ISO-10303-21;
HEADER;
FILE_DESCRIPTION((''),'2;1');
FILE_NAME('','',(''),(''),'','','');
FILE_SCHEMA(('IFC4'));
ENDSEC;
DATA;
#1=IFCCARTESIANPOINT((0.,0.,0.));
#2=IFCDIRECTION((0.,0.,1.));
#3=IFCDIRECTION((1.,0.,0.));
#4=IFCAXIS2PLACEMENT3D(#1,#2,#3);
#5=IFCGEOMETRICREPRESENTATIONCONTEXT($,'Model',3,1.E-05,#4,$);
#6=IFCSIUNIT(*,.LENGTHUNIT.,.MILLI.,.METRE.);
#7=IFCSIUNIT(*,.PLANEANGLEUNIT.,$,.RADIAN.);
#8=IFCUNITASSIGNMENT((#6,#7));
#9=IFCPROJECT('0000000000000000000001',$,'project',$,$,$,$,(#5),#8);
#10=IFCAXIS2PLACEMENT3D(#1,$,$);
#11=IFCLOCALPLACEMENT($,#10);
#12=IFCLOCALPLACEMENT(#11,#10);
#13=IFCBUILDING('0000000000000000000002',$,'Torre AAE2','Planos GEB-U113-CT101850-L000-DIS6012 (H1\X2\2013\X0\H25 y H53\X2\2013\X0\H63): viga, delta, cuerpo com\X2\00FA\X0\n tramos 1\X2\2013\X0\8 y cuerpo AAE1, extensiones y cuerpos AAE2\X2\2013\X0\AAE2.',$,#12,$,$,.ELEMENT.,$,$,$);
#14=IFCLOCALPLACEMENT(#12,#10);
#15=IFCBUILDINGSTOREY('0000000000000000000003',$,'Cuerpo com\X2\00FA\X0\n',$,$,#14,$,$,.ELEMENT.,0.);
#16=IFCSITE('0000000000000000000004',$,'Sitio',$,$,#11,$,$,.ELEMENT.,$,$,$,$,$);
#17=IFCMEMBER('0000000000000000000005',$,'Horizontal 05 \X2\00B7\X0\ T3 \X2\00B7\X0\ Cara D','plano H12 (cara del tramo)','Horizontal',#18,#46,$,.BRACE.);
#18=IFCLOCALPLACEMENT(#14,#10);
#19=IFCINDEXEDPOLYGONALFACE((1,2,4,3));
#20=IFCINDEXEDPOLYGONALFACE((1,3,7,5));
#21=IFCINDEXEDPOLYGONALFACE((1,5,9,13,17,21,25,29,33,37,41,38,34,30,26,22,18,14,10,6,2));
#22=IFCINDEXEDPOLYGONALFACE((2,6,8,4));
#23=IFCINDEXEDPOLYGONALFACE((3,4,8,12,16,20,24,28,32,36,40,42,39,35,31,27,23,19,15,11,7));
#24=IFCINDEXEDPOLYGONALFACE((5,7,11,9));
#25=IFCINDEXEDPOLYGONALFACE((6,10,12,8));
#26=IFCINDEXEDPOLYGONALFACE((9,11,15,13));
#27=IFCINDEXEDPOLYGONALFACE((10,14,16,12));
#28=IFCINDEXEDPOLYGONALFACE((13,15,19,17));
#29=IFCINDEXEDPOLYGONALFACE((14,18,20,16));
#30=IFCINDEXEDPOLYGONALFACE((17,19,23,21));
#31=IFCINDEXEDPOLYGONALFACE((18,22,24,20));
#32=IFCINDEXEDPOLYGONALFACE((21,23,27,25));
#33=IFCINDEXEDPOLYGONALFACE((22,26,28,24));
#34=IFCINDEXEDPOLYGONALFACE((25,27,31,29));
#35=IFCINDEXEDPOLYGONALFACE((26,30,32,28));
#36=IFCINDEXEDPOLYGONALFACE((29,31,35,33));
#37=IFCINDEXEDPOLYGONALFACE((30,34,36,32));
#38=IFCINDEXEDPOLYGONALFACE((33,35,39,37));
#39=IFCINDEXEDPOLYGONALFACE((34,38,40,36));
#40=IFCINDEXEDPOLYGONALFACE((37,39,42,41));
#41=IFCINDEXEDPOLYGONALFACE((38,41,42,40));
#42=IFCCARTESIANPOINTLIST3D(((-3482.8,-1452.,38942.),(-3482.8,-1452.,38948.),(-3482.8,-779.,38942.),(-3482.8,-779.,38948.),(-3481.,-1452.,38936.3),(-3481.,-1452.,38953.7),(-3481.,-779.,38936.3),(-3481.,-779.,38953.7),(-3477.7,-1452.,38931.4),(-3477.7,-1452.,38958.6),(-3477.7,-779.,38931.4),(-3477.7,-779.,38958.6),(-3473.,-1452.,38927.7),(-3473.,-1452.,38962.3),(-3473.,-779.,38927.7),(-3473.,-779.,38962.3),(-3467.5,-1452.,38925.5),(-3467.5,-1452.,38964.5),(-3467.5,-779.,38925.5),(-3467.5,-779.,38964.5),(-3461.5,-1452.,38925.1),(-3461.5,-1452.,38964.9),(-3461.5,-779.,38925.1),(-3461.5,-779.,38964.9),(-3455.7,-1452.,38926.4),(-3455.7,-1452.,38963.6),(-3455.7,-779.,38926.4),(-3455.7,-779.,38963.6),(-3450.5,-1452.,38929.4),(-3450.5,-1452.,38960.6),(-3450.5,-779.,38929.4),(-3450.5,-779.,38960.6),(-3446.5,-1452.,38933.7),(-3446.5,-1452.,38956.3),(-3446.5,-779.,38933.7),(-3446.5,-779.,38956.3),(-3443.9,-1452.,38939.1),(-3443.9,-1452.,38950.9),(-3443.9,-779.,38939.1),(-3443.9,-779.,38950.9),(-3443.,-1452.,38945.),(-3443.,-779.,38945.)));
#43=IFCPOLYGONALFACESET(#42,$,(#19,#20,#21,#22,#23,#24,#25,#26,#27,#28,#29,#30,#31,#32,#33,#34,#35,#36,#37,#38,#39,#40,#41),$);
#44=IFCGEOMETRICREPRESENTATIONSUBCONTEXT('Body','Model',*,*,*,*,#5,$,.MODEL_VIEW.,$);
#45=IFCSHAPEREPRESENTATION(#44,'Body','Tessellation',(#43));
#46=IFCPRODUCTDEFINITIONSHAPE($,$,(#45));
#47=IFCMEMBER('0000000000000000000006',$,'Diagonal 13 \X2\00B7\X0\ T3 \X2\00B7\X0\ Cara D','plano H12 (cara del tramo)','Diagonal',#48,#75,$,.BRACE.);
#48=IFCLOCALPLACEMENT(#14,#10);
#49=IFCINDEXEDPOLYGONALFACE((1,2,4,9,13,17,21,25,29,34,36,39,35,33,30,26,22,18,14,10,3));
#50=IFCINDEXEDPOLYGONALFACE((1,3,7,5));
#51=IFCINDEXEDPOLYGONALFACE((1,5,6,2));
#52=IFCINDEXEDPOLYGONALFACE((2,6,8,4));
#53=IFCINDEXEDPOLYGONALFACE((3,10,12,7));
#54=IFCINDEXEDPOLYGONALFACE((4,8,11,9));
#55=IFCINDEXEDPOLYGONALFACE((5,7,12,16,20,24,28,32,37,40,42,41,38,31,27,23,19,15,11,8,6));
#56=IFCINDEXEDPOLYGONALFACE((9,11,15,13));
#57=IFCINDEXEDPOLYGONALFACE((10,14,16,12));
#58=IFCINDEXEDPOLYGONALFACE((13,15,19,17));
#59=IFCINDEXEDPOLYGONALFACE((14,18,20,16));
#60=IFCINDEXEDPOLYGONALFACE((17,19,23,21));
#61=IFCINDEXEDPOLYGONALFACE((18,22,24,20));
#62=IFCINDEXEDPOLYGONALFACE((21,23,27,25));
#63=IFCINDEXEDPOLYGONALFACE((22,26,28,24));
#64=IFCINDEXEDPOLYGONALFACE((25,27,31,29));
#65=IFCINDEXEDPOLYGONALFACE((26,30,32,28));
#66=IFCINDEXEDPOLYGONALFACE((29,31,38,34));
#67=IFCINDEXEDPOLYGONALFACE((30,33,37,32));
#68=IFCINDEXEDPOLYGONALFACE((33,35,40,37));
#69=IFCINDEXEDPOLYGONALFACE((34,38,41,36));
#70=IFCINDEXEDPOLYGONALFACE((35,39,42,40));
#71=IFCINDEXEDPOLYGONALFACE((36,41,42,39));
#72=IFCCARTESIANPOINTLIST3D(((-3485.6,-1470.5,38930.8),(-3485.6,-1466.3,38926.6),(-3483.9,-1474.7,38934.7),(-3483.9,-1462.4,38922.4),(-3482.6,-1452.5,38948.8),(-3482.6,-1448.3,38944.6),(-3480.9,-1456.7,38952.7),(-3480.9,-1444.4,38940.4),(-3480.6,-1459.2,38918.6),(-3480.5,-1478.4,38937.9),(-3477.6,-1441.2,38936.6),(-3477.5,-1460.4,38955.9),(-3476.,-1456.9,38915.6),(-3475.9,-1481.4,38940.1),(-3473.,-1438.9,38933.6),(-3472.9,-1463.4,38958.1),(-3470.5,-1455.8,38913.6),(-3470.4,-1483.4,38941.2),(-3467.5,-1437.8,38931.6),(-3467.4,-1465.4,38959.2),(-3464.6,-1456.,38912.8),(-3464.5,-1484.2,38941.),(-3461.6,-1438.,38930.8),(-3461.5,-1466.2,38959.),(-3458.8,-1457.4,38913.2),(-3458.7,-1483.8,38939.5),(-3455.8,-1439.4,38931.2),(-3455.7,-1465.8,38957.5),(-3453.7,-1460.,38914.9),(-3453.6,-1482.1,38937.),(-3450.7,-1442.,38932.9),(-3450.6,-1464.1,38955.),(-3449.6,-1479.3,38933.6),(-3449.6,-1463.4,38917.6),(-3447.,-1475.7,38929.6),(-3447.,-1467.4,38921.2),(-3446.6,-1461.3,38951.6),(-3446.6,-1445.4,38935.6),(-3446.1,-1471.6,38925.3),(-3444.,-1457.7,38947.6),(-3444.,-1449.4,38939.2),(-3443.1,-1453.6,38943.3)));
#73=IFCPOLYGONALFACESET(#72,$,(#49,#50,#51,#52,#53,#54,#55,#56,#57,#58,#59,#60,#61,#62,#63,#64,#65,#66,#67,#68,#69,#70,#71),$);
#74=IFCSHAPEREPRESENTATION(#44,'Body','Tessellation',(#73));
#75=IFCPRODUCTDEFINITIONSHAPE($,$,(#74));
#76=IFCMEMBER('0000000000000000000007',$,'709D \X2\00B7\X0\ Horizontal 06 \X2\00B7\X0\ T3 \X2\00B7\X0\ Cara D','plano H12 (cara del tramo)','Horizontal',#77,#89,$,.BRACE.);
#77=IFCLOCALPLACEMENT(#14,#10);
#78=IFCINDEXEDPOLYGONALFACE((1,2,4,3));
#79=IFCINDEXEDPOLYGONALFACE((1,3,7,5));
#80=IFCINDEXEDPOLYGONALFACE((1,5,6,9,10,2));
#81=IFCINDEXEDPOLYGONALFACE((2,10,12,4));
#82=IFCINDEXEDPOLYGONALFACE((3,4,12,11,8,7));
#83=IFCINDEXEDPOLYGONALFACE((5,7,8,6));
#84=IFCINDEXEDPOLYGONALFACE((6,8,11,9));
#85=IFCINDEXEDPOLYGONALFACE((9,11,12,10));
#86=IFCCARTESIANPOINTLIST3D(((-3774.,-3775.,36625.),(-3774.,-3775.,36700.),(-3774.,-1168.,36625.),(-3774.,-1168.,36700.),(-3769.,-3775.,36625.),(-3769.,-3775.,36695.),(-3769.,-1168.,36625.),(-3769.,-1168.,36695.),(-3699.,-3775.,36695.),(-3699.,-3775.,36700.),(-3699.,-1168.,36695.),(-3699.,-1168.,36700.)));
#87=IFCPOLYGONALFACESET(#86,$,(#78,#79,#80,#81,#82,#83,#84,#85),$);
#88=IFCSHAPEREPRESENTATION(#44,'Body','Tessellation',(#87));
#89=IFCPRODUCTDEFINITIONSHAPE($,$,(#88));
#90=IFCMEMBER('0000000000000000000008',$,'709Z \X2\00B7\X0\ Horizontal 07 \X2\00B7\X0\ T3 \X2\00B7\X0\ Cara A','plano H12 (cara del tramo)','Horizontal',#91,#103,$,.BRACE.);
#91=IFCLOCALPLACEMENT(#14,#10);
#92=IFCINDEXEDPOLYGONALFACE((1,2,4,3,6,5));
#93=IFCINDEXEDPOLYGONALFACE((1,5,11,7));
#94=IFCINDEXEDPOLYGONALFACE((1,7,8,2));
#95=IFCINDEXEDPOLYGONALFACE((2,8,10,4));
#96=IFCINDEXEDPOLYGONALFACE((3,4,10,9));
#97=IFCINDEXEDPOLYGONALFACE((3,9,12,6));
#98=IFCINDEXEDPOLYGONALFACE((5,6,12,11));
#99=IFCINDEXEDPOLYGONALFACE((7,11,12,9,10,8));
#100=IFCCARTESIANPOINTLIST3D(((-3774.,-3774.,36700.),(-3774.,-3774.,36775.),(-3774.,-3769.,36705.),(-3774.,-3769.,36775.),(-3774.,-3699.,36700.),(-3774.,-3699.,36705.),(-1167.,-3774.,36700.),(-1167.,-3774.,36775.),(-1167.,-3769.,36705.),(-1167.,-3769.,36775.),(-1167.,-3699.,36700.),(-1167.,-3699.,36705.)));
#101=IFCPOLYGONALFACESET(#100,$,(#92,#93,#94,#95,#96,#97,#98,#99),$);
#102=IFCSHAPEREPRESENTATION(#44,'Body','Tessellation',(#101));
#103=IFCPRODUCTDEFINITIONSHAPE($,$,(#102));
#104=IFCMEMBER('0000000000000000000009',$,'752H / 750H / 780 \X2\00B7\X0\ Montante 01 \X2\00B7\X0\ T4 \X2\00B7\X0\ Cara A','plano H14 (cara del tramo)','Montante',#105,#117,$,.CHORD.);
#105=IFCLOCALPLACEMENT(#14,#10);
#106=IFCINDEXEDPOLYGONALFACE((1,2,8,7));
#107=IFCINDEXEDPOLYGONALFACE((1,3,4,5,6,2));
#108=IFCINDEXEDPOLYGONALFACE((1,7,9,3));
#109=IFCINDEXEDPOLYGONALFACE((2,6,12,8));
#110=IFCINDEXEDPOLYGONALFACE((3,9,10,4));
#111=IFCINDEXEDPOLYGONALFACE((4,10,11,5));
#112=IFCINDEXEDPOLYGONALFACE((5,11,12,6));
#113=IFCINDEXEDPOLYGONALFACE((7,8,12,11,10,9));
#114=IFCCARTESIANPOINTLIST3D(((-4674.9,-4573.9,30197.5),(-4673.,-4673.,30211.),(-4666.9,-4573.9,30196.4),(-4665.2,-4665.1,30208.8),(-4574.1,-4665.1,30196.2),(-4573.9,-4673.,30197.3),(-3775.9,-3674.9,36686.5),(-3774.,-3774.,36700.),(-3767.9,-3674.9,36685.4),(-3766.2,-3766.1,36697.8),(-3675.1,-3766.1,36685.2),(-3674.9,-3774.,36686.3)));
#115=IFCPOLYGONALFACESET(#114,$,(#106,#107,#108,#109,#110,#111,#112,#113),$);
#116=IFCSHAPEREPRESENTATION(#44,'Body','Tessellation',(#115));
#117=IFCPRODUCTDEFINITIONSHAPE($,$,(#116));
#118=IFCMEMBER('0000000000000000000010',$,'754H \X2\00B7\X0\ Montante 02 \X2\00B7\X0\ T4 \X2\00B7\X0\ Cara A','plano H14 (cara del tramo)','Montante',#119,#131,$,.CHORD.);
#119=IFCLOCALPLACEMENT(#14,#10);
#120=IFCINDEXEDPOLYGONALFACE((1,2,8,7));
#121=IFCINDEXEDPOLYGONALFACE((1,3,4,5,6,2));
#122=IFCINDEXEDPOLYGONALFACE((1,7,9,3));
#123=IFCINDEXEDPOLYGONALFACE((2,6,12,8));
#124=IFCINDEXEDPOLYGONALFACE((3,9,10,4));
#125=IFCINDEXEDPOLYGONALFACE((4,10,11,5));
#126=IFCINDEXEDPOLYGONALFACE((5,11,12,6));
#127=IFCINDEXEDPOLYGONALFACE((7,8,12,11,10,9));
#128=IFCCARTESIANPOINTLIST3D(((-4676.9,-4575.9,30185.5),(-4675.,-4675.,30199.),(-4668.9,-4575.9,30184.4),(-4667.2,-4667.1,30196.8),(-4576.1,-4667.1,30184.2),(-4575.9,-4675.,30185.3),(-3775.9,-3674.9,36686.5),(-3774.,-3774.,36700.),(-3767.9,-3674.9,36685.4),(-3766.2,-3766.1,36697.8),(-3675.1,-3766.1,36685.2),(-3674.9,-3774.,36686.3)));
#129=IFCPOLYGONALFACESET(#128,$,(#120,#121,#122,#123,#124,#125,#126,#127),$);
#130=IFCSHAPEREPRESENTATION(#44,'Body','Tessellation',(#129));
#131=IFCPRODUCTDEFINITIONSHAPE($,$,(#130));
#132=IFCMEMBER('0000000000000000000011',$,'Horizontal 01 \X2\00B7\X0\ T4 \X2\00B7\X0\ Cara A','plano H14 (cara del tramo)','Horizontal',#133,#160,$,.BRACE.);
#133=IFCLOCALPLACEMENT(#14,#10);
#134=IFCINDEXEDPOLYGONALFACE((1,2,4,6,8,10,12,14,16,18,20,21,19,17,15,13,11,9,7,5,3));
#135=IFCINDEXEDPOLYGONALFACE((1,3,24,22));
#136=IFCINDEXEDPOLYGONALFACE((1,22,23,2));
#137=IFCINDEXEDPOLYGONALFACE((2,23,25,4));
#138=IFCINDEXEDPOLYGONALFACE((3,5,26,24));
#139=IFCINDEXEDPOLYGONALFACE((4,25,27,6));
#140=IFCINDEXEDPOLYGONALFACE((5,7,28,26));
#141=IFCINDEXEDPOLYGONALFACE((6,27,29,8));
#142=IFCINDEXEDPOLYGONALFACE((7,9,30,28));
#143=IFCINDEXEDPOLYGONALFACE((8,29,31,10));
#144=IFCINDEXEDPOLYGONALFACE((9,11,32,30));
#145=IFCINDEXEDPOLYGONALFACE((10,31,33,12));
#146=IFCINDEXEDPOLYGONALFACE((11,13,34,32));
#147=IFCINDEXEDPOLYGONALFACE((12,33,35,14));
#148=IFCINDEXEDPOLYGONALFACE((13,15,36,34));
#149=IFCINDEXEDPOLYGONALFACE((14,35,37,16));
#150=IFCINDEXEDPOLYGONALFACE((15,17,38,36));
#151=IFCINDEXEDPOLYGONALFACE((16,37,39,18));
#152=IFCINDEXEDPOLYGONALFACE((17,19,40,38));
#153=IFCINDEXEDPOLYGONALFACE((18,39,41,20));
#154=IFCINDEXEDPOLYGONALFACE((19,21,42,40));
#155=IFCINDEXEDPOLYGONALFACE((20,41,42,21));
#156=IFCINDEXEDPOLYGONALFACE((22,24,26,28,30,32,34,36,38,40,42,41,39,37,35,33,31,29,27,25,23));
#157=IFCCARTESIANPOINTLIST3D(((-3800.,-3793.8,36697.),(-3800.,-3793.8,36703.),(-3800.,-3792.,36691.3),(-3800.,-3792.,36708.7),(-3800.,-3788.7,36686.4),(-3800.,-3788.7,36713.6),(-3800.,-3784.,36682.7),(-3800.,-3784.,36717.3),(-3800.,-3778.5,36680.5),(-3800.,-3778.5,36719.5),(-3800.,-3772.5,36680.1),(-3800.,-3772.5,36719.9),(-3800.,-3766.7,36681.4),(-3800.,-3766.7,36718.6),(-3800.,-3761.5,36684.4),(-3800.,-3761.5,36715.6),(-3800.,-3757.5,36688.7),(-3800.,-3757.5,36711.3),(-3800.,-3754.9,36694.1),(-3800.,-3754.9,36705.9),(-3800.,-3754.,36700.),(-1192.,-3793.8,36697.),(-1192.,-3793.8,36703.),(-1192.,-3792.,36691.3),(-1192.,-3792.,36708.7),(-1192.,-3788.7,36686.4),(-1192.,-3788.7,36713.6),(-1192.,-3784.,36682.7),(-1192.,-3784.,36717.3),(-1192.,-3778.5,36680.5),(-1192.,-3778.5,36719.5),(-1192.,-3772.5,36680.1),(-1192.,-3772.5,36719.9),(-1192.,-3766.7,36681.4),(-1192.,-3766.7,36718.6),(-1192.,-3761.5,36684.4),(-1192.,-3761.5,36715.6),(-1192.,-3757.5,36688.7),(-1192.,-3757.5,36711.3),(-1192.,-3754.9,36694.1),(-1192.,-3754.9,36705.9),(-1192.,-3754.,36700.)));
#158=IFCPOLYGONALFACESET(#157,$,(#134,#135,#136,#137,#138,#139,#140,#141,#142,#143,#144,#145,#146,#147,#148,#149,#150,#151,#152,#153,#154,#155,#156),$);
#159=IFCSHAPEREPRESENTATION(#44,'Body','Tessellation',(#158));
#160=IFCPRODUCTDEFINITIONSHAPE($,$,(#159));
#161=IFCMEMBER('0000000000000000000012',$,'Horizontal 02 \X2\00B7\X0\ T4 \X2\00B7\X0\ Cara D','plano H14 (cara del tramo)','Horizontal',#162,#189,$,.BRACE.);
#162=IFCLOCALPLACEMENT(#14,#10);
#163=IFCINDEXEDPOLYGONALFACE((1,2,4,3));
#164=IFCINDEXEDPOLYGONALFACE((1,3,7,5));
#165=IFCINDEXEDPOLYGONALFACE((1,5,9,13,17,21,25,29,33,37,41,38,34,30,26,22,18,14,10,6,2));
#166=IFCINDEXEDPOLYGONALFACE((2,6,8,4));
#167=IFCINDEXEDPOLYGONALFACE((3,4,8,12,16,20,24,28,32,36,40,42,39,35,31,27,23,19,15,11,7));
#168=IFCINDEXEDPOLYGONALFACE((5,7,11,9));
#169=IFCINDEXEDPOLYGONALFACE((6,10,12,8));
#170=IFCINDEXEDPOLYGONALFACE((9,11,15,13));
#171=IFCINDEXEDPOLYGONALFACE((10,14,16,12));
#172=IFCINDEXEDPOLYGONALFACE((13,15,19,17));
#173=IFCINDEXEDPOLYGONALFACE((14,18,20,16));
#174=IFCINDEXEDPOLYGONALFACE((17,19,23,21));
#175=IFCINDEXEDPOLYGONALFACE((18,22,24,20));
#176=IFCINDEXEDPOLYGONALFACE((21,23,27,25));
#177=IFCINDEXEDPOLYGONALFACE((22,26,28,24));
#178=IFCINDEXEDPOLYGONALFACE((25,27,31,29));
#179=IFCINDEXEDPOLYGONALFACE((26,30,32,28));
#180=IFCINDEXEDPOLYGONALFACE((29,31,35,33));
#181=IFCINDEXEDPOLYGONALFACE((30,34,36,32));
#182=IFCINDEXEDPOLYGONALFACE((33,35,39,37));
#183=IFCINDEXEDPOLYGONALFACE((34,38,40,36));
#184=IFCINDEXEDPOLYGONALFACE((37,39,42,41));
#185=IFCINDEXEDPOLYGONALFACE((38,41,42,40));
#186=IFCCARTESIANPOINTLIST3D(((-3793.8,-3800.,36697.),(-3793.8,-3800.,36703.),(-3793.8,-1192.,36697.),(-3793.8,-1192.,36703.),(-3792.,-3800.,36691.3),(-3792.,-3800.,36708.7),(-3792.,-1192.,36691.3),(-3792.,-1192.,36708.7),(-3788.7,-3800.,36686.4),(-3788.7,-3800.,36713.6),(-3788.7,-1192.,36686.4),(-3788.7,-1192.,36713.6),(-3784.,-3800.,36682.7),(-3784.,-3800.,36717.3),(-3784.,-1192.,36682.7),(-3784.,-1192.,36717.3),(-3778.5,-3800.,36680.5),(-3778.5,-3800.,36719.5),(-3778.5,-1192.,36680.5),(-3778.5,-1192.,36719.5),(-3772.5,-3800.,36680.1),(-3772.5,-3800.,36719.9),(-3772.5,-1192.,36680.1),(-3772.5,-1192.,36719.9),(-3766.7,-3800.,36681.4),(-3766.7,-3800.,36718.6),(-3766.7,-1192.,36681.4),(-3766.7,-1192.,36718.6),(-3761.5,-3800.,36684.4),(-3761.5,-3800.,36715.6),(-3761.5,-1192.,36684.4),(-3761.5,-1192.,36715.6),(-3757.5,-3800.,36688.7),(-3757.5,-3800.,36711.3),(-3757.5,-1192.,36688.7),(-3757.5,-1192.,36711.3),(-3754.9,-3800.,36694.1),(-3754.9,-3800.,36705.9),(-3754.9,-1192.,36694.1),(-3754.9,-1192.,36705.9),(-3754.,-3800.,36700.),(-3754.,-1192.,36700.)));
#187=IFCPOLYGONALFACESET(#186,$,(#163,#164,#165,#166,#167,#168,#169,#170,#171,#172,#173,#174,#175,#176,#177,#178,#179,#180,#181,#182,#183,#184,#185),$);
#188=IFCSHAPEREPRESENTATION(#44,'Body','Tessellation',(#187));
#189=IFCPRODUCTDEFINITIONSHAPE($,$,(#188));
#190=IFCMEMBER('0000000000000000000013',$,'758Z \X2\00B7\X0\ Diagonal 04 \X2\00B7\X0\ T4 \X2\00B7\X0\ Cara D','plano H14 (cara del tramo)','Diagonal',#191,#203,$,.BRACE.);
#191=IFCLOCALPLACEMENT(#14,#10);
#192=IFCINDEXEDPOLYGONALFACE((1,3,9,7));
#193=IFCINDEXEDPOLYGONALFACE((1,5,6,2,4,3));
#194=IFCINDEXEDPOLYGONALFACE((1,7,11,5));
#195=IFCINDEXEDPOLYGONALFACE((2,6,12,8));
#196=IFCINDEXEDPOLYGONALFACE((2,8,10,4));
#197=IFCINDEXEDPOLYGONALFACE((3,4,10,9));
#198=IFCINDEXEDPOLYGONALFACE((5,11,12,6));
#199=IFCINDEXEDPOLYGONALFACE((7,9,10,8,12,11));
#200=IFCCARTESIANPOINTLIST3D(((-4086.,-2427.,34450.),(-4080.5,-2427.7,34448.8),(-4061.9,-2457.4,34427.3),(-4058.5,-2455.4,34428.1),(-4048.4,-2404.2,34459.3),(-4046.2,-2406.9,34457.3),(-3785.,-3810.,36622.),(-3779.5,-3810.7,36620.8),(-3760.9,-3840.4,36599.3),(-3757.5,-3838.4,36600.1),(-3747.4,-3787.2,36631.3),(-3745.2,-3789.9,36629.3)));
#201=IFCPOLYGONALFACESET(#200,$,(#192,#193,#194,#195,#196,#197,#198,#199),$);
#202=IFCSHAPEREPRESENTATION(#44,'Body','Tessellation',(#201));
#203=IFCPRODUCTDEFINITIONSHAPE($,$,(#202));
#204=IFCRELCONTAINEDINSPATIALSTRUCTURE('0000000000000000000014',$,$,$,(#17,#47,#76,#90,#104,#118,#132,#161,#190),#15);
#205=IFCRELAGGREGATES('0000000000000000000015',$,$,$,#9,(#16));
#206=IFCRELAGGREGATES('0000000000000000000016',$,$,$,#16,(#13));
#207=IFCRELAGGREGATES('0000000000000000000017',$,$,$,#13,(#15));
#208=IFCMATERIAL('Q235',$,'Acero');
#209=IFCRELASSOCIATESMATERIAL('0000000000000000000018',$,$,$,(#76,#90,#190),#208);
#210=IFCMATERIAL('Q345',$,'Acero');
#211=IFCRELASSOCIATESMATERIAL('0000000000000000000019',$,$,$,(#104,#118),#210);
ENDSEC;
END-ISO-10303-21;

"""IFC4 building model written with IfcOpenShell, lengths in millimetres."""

from ifc_helpers import new_model, si_unit, frame, frame_2d, origin, origin_with_axes, place, context, subcontext, project, spatial, circle, l_section, extrude, material, element, save


model = new_model("IFC4")

# Units and contexts
model_context = context("Model", 3, precision=1e-05, world=origin_with_axes())
body_context = subcontext(model_context, "Body", "Model", "MODEL_VIEW")
ifc_project = project(units=[si_unit("LENGTHUNIT", "METRE", prefix="MILLI"), si_unit("PLANEANGLEUNIT", "RADIAN")], contexts=[model_context])

# Site, building, storey
site_placement = place(None, origin())
site = spatial("IfcSite", under=ifc_project, at=site_placement, Name="Sitio", CompositionType="ELEMENT")
building_placement = place(site_placement, origin())
building = spatial("IfcBuilding", under=site, at=building_placement, Name="Torre AAE2", Description="Planos GEB-U113-CT101850-L000-DIS6012 (H1–H25 y H53–H63): viga, delta, cuerpo común tramos 1–8 y cuerpo AAE1, extensiones y cuerpos AAE2–AAE2.", CompositionType="ELEMENT")
storey_placement = place(building_placement, origin())
storey = spatial("IfcBuildingStorey", under=building, at=storey_placement, Name="Cuerpo común", CompositionType="ELEMENT", Elevation=0.0)

# Members
ifc_material_1 = material(Name="Q235", Category="Acero")
ifc_material_2 = material(Name="Q345", Category="Acero")
member_1_placement = place(storey_placement, frame((-3463.0, -779.0, 38945.0), z_axis=(0.0, -1.0, 0.0), x_axis=(1.0, 0.0, 0.0)))
element("IfcMember", 1, at=member_1_placement, inside=storey, Name="Horizontal 05 · T3 · Cara D", Description="plano H12 (cara del tramo)", ObjectType="Horizontal", PredefinedType="BRACE", context=body_context, shape_type="SweptSolid", body=[
    extrude(circle(Radius=20.0), None, (0.0, 0.0, 1.0), 673.0),
])
member_2_placement = place(storey_placement, frame((-3463.0, -1452.0, 38945.0), z_axis=(-0.117041, -0.702247, -0.702247), x_axis=(0.948273, 0.131084, -0.289129)))
element("IfcMember", 2, at=member_2_placement, inside=storey, Name="Diagonal 13 · T3 · Cara D", Description="plano H12 (cara del tramo)", ObjectType="Diagonal", PredefinedType="BRACE", context=body_context, shape_type="SweptSolid", body=[
    extrude(circle(Radius=20.0), None, (0.0, 0.0, 1.0), 25.6),
])
for number, where, z_axis, x_axis, name in (
    (3, (-3774.0, -3775.0, 36700.0), (0.0, 1.0, 0.0), (1.0, 0.0, 0.0), "709D · Horizontal 06 · T3 · Cara D"),
    (4, (-3774.0, -3774.0, 36700.0), (1.0, 0.0, 0.0), (0.0, 1.0, 0.0), "709Z · Horizontal 07 · T3 · Cara A"),
):
    element("IfcMember", number, at=place(storey_placement, frame(where, z_axis=z_axis, x_axis=x_axis)), inside=storey, material=ifc_material_1, Name=name, Description="plano H12 (cara del tramo)", ObjectType="Horizontal", PredefinedType="BRACE", context=body_context, shape_type="SweptSolid", body=[
        extrude(l_section(Depth=75.0, Width=75.0, Thickness=5.0, at=frame_2d((37.5, 37.5))), None, (0.0, 0.0, 1.0), 2607.0),
    ])
member_3_placement = place(storey_placement, frame((-3774.0, -3774.0, 36700.0), z_axis=(-0.135957, -0.135957, -0.981342), x_axis=(-0.018658, 0.990715, -0.134671)))
element("IfcMember", 5, at=member_3_placement, inside=storey, material=ifc_material_2, Name="752H / 750H / 780 · Montante 01 · T4 · Cara A", Description="plano H14 (cara del tramo)", ObjectType="Montante", PredefinedType="CHORD", context=body_context, shape_type="SweptSolid", body=[
    extrude(l_section(Depth=100.0, Width=100.0, Thickness=8.0, at=frame_2d((50.0, 50.0))), None, (0.0, 0.0, 1.0), 6612.4),
])
member_4_placement = place(storey_placement, frame((-3774.0, -3774.0, 36700.0), z_axis=(-0.136006, -0.136006, -0.981328), x_axis=(-0.018671, 0.990708, -0.134719)))
element("IfcMember", 6, at=member_4_placement, inside=storey, material=ifc_material_2, Name="754H · Montante 02 · T4 · Cara A", Description="plano H14 (cara del tramo)", ObjectType="Montante", PredefinedType="CHORD", context=body_context, shape_type="SweptSolid", body=[
    extrude(l_section(Depth=100.0, Width=100.0, Thickness=8.0, at=frame_2d((50.0, 50.0))), None, (0.0, 0.0, 1.0), 6624.7),
])
for number, where, z_axis, x_axis, name in (
    (7, (-3800.0, -3774.0, 36700.0), (1.0, 0.0, 0.0), (0.0, 1.0, 0.0), "Horizontal 01 · T4 · Cara A"),
    (8, (-3774.0, -3800.0, 36700.0), (0.0, 1.0, 0.0), (1.0, 0.0, 0.0), "Horizontal 02 · T4 · Cara D"),
):
    element("IfcMember", number, at=place(storey_placement, frame(where, z_axis=z_axis, x_axis=x_axis)), inside=storey, Name=name, Description="plano H14 (cara del tramo)", ObjectType="Horizontal", PredefinedType="BRACE", context=body_context, shape_type="SweptSolid", body=[
        extrude(circle(Radius=20.0), None, (0.0, 0.0, 1.0), 2608.0),
    ])
member_5_placement = place(storey_placement, frame((-3785.0, -3810.0, 36622.0), z_axis=(-0.116106, 0.533469, -0.837813), x_axis=(0.836171, 0.507736, 0.207418)))
element("IfcMember", 9, at=member_5_placement, inside=storey, material=ifc_material_1, Name="758Z · Diagonal 04 · T4 · Cara D", Description="plano H14 (cara del tramo)", ObjectType="Diagonal", PredefinedType="BRACE", context=body_context, shape_type="SweptSolid", body=[
    extrude(l_section(Depth=45.0, Width=45.0, Thickness=4.0, at=frame_2d((22.5, 22.5))), None, (0.0, 0.0, 1.0), 2592.5),
])

save(model, "model.ifc")
